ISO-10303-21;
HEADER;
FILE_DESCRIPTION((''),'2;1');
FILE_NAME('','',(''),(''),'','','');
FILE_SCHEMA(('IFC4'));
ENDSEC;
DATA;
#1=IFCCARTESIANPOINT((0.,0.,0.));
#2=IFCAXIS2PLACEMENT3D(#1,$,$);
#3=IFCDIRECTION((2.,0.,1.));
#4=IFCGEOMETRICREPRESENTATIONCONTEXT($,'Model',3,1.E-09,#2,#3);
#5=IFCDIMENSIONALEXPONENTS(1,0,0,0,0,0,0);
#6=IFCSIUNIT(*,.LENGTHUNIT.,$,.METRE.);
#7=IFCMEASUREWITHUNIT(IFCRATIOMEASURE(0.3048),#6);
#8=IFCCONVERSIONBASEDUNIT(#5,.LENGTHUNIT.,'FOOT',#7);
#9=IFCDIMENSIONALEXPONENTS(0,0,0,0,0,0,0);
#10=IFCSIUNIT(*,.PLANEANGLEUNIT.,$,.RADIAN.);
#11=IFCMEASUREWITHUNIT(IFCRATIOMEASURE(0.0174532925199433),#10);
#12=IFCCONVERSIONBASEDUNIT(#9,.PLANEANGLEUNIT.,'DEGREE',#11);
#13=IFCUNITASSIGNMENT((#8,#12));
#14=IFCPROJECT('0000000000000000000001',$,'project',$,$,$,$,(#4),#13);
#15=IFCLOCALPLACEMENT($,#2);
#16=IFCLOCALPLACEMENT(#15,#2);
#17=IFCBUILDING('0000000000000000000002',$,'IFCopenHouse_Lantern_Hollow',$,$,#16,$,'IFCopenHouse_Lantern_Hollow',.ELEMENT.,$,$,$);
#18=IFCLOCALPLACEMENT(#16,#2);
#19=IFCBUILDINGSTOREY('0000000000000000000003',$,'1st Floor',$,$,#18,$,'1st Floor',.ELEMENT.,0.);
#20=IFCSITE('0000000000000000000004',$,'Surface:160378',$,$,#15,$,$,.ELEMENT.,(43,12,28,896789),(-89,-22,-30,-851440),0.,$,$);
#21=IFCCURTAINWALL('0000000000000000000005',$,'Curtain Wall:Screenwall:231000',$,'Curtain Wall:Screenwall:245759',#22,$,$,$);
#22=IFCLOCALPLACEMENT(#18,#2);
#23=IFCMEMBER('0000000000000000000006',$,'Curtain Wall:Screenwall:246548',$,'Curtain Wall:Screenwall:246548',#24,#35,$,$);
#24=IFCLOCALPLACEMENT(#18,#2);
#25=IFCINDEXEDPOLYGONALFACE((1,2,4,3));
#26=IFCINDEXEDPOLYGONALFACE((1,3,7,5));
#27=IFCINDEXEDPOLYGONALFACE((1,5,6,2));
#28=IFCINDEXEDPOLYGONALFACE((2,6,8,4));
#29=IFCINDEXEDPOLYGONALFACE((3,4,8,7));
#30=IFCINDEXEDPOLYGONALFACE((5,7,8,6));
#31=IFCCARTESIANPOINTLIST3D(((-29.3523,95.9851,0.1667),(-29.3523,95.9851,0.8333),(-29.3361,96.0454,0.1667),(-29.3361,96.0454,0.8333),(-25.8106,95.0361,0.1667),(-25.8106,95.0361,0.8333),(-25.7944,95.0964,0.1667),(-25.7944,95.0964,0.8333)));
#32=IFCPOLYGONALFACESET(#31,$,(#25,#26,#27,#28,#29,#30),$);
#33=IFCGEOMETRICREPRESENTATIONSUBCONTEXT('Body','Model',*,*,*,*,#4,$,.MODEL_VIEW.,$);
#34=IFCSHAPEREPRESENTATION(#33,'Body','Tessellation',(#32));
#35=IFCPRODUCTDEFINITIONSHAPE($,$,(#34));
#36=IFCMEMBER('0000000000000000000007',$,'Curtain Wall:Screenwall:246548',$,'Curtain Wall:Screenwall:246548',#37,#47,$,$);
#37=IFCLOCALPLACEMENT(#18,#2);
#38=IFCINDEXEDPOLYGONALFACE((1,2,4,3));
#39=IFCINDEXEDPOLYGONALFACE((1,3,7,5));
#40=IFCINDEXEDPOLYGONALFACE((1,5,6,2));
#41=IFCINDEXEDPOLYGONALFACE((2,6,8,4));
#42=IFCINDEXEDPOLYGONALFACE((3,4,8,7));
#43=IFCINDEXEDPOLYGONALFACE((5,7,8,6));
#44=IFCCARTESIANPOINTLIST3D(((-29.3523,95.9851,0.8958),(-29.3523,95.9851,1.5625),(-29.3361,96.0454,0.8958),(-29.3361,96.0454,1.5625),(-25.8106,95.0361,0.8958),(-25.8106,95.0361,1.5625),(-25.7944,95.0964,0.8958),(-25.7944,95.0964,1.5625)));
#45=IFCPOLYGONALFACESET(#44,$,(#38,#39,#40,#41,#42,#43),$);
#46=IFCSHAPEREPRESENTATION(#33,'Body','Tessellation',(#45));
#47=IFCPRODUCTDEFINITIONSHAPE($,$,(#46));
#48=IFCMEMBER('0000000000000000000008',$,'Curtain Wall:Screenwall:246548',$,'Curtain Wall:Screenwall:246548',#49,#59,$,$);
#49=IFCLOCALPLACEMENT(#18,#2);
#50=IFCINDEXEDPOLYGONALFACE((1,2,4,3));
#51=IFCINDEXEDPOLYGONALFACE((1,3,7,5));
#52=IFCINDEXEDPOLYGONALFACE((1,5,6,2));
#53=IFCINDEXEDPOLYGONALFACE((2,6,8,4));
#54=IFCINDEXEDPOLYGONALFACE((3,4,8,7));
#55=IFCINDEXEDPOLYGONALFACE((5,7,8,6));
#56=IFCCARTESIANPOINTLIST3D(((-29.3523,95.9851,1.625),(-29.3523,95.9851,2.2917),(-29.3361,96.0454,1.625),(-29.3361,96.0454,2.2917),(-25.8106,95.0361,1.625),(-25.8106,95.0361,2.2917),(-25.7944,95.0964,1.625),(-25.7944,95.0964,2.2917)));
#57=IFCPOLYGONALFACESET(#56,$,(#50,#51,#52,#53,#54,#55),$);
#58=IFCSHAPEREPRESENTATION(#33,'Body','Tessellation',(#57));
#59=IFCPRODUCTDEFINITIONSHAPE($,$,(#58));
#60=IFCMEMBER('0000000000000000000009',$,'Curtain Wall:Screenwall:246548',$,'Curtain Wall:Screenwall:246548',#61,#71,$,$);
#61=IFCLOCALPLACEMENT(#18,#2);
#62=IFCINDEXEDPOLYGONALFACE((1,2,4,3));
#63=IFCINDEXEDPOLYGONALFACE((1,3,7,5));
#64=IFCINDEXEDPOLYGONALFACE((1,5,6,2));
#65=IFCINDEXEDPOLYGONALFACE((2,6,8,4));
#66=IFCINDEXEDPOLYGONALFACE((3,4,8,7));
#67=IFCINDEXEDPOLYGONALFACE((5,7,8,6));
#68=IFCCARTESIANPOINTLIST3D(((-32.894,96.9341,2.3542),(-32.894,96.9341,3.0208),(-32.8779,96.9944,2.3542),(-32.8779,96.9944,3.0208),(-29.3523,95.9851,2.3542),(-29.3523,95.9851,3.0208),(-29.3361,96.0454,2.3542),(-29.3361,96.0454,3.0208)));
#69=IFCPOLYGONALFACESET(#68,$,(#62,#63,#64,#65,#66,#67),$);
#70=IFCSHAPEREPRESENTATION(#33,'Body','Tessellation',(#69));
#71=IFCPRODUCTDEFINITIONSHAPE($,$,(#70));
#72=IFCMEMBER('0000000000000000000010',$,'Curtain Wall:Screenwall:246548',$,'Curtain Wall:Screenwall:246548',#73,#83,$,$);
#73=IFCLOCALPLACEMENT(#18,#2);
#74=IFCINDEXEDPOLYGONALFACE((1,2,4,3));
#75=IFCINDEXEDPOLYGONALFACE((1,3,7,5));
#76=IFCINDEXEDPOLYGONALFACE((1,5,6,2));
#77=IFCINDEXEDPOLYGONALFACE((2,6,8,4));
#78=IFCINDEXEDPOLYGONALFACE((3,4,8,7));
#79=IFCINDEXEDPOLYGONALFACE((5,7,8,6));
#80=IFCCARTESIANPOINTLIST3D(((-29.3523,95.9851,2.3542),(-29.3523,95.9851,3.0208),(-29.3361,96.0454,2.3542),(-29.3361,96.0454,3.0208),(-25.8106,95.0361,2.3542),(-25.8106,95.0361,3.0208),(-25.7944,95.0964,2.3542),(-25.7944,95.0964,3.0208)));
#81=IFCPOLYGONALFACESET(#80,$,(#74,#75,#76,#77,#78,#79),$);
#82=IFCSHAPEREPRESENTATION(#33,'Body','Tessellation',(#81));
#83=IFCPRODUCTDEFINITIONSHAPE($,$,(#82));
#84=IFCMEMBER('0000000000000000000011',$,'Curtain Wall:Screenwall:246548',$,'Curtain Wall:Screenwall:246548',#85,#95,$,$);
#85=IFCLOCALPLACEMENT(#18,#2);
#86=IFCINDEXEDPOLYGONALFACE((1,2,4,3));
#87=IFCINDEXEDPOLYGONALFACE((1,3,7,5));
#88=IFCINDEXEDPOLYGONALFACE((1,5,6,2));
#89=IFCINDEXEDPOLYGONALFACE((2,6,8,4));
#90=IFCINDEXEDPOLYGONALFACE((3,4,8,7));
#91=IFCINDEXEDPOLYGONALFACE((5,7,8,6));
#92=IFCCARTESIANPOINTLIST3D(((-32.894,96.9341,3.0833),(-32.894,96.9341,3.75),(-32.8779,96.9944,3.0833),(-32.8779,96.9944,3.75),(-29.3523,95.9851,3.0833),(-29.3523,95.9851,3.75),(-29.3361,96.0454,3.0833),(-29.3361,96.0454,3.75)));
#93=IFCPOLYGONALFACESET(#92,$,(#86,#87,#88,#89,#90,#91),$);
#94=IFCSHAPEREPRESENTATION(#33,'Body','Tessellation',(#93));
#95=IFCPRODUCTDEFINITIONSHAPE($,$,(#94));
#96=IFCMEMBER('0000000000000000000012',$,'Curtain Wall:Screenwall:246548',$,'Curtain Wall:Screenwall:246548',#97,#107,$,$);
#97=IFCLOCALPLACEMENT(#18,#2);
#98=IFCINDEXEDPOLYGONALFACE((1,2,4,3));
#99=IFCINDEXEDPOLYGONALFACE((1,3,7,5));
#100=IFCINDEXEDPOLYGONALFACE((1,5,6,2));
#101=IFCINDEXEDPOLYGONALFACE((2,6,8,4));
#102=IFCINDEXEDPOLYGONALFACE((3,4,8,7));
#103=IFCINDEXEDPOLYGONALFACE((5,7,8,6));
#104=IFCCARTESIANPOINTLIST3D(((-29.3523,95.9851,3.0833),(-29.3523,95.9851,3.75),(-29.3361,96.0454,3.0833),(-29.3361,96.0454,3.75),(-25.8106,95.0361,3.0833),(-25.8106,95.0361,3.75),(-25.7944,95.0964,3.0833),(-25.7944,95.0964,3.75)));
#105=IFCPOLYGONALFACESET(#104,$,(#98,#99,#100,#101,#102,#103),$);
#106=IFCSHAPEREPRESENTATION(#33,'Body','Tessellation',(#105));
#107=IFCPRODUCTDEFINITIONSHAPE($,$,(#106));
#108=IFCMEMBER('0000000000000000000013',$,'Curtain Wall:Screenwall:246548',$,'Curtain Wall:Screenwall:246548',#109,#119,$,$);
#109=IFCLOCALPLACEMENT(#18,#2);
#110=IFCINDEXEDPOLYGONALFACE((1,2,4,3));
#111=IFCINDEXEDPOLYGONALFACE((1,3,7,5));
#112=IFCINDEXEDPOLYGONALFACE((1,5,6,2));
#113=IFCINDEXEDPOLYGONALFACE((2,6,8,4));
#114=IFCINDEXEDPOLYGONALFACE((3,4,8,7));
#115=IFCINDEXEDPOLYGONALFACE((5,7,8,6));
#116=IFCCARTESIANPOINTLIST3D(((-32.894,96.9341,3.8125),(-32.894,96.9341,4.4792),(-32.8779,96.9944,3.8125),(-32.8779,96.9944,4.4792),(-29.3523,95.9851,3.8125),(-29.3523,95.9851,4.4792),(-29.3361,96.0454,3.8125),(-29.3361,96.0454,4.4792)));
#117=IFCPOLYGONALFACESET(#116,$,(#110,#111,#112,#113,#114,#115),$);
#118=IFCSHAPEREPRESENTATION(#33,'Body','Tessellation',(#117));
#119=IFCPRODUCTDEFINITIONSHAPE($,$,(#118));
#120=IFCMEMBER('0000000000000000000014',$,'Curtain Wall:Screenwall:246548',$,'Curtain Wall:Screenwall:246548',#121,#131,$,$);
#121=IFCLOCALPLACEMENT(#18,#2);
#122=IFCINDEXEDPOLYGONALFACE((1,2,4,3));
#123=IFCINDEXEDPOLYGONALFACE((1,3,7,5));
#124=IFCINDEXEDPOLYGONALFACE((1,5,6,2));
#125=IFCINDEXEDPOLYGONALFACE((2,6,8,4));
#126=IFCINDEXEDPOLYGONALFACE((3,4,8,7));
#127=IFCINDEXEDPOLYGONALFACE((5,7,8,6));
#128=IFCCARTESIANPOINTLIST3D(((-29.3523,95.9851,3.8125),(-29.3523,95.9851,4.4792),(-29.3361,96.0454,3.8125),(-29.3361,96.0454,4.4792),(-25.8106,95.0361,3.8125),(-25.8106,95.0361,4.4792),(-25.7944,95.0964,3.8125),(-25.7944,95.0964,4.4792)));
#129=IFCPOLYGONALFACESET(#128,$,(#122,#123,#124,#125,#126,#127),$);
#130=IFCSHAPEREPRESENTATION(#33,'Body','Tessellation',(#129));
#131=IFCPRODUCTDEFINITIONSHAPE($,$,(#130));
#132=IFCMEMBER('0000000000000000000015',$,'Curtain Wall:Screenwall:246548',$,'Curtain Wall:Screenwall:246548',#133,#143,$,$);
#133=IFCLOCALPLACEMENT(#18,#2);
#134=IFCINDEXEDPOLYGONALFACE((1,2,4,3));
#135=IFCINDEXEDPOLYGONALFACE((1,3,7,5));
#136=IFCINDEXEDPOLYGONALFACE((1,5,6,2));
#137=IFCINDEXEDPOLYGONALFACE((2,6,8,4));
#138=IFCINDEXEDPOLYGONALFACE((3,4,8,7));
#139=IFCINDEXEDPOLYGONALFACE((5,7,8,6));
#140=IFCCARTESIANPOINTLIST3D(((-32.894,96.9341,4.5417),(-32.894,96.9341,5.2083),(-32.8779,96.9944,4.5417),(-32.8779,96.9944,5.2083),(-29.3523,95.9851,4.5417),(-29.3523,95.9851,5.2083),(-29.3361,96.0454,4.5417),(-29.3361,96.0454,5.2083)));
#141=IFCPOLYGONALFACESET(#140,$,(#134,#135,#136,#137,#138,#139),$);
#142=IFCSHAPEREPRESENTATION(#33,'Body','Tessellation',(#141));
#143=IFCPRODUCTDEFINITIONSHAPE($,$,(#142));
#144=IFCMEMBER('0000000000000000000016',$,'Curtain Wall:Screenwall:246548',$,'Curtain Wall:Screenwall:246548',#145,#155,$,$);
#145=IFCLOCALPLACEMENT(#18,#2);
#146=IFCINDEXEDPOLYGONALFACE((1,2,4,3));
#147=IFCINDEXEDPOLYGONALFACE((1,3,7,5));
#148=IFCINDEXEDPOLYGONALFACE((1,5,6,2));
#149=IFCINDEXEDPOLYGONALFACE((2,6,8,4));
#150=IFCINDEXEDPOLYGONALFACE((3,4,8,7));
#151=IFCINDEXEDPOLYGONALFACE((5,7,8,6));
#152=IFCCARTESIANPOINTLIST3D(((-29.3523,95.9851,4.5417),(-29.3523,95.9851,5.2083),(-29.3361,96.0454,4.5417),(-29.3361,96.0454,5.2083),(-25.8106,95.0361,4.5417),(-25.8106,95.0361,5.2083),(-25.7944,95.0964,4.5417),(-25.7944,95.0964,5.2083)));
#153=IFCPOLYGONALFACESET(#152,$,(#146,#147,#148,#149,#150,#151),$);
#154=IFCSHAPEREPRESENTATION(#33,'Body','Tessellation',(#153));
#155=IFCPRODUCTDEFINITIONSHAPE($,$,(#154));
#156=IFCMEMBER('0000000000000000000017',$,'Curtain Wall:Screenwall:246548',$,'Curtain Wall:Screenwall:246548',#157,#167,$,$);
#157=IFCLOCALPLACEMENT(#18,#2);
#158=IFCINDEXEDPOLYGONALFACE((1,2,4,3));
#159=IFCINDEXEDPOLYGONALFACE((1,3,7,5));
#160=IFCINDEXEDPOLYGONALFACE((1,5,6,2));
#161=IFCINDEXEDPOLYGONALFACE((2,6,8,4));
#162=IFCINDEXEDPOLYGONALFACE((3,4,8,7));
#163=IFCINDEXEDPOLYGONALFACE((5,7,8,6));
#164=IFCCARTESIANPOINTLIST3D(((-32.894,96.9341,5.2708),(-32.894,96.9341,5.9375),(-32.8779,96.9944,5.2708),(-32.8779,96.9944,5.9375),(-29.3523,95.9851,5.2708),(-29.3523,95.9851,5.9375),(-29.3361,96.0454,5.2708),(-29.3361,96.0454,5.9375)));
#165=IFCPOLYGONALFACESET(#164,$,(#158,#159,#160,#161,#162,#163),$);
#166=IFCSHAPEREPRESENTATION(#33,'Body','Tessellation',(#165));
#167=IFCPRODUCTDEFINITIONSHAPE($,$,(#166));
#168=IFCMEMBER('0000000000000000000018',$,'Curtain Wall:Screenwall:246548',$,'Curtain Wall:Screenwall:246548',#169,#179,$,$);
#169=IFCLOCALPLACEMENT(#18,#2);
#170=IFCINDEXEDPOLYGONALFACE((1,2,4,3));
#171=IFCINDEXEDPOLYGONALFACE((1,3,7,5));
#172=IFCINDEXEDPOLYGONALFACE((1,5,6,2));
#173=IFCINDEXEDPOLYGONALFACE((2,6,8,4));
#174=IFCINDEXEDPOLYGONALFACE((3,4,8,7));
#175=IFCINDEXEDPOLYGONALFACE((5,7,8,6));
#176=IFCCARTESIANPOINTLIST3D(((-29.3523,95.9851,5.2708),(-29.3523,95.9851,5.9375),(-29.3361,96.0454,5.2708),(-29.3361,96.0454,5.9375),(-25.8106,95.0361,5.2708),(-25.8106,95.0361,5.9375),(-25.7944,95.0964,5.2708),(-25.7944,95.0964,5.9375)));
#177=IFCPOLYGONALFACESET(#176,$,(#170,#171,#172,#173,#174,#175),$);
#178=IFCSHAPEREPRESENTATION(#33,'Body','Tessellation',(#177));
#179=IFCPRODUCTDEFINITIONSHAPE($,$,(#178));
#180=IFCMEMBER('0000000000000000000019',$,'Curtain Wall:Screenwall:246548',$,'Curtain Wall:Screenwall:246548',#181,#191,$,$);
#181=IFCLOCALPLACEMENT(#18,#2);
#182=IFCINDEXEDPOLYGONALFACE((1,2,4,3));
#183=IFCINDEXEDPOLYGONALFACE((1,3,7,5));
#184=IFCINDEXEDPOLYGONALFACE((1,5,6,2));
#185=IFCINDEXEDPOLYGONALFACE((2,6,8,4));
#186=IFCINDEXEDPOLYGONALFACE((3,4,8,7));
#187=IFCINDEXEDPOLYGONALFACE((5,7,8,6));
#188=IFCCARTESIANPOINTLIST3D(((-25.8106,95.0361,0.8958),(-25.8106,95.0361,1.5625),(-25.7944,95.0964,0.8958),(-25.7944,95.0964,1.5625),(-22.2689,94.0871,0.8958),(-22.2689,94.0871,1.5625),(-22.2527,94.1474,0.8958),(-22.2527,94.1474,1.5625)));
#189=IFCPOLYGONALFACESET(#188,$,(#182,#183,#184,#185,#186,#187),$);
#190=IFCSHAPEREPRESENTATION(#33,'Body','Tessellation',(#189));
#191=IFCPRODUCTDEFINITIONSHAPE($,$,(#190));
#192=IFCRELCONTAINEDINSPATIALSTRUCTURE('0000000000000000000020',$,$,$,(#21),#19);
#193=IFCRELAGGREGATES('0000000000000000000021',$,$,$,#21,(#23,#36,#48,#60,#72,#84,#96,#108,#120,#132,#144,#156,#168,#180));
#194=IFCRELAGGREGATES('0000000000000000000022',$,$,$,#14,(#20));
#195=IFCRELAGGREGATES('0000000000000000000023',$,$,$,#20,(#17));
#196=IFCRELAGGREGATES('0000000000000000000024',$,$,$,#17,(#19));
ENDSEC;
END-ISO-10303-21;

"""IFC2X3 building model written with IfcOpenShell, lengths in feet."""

from ifc_helpers import new_model, entity, si_unit, converted_unit, direction, frame, frame_2d, origin, origin_2d_with_axis, place, context, subcontext, project, spatial, rectangle, extrude, element, aggregate, save


model = new_model("IFC2X3")

# Units and contexts
model_context = context("Model", 3, precision=1e-09, world=origin(), true_north=direction((2.0, 0.0, 1.0)))
body_context = subcontext(model_context, "Body", "Model", "MODEL_VIEW")
ifc_project = project(units=[converted_unit("LENGTHUNIT", "FOOT", entity("IfcRatioMeasure", 0.3048), si_unit("LENGTHUNIT", "METRE"), dimensions=[1, 0, 0, 0, 0, 0, 0]), converted_unit("PLANEANGLEUNIT", "DEGREE", entity("IfcRatioMeasure", 0.0174532925199433), si_unit("PLANEANGLEUNIT", "RADIAN"), dimensions=[0, 0, 0, 0, 0, 0, 0])], contexts=[model_context])

# Site, building, storey
site_placement = place(None, origin())
site = spatial("IfcSite", under=ifc_project, at=site_placement, Name="Surface:160378", CompositionType="ELEMENT", RefLatitude=(43, 12, 28, 896789), RefLongitude=(-89, -22, -30, -851440), RefElevation=0.0)
building_placement = place(site_placement, origin())
building = spatial("IfcBuilding", under=site, at=building_placement, Name="IFCopenHouse_Lantern_Hollow", LongName="IFCopenHouse_Lantern_Hollow", CompositionType="ELEMENT")
storey_placement = place(building_placement, origin())
storey = spatial("IfcBuildingStorey", under=building, at=storey_placement, Name="1st Floor", LongName="1st Floor", CompositionType="ELEMENT", Elevation=0.0)

# Curtain wall, members
curtain_wall_placement = place(storey_placement, origin())
curtain_wall = element("IfcCurtainWall", 1, at=curtain_wall_placement, inside=storey, Name="Curtain Wall:Screenwall:231000", ObjectType="Curtain Wall:Screenwall:245759")
member_1_placement = place(curtain_wall_placement, frame((-29.3523, 95.0361, 0.1667)))
member_1 = element("IfcMember", 2, at=member_1_placement, Name="Curtain Wall:Screenwall:246548", ObjectType="Curtain Wall:Screenwall:246548", context=body_context, shape_type="SweptSolid", body=[
    extrude(rectangle(XDim=3.6667, YDim=0.0625, at=frame_2d((0.0, 0.0), x_axis=(1.0, 0.0))), frame((1.779, 0.5047, 0.0), z_axis=(0.0, 0.0, 1.0), x_axis=(-0.965926, 0.258819, 0.0)), (0.0, 0.0, 1.0), 0.6667),
])
member_2_placement = place(curtain_wall_placement, frame((-29.3523, 95.0361, 0.8958)))
member_2 = element("IfcMember", 3, at=member_2_placement, Name="Curtain Wall:Screenwall:246548", ObjectType="Curtain Wall:Screenwall:246548", context=body_context, shape_type="SweptSolid", body=[
    extrude(rectangle(XDim=3.6667, YDim=0.0625, at=frame_2d((0.0, 0.0), x_axis=(1.0, 0.0))), frame((1.779, 0.5047, 0.0), z_axis=(0.0, 0.0, 1.0), x_axis=(-0.965926, 0.258819, 0.0)), (0.0, 0.0, 1.0), 0.6667),
])
member_3_placement = place(curtain_wall_placement, frame((-29.3523, 95.0361, 1.625)))
member_3 = element("IfcMember", 4, at=member_3_placement, Name="Curtain Wall:Screenwall:246548", ObjectType="Curtain Wall:Screenwall:246548", context=body_context, shape_type="SweptSolid", body=[
    extrude(rectangle(XDim=3.6667, YDim=0.0625, at=frame_2d((0.0, 0.0), x_axis=(1.0, 0.0))), frame((1.779, 0.5047, 0.0), z_axis=(0.0, 0.0, 1.0), x_axis=(-0.965926, 0.258819, 0.0)), (0.0, 0.0, 1.0), 0.6667),
])
member_4_placement = place(curtain_wall_placement, frame((-32.894, 95.9851, 2.3542)))
member_4 = element("IfcMember", 5, at=member_4_placement, Name="Curtain Wall:Screenwall:246548", ObjectType="Curtain Wall:Screenwall:246548", context=body_context, shape_type="SweptSolid", body=[
    extrude(rectangle(XDim=3.6667, YDim=0.0625, at=frame_2d((0.0, 0.0), x_axis=(1.0, 0.0))), frame((1.779, 0.5047, 0.0), z_axis=(0.0, 0.0, 1.0), x_axis=(-0.965926, 0.258819, 0.0)), (0.0, 0.0, 1.0), 0.6667),
])
member_5_placement = place(curtain_wall_placement, frame((-29.3523, 95.0361, 2.3542)))
member_5 = element("IfcMember", 6, at=member_5_placement, Name="Curtain Wall:Screenwall:246548", ObjectType="Curtain Wall:Screenwall:246548", context=body_context, shape_type="SweptSolid", body=[
    extrude(rectangle(XDim=3.6667, YDim=0.0625, at=frame_2d((0.0, 0.0), x_axis=(1.0, 0.0))), frame((1.779, 0.5047, 0.0), z_axis=(0.0, 0.0, 1.0), x_axis=(-0.965926, 0.258819, 0.0)), (0.0, 0.0, 1.0), 0.6667),
])
member_6_placement = place(curtain_wall_placement, frame((-32.894, 95.9851, 3.0833)))
member_6 = element("IfcMember", 7, at=member_6_placement, Name="Curtain Wall:Screenwall:246548", ObjectType="Curtain Wall:Screenwall:246548", context=body_context, shape_type="SweptSolid", body=[
    extrude(rectangle(XDim=3.6667, YDim=0.0625, at=frame_2d((0.0, 0.0), x_axis=(1.0, 0.0))), frame((1.779, 0.5047, 0.0), z_axis=(0.0, 0.0, 1.0), x_axis=(-0.965926, 0.258819, 0.0)), (0.0, 0.0, 1.0), 0.6667),
])
member_7_placement = place(curtain_wall_placement, frame((-29.3523, 95.0361, 3.0833)))
member_7 = element("IfcMember", 8, at=member_7_placement, Name="Curtain Wall:Screenwall:246548", ObjectType="Curtain Wall:Screenwall:246548", context=body_context, shape_type="SweptSolid", body=[
    extrude(rectangle(XDim=3.6667, YDim=0.0625, at=frame_2d((0.0, 0.0), x_axis=(1.0, 0.0))), frame((1.779, 0.5047, 0.0), z_axis=(0.0, 0.0, 1.0), x_axis=(-0.965926, 0.258819, 0.0)), (0.0, 0.0, 1.0), 0.6667),
])
member_8_placement = place(curtain_wall_placement, frame((-32.894, 95.9851, 3.8125)))
member_8 = element("IfcMember", 9, at=member_8_placement, Name="Curtain Wall:Screenwall:246548", ObjectType="Curtain Wall:Screenwall:246548", context=body_context, shape_type="SweptSolid", body=[
    extrude(rectangle(XDim=3.6667, YDim=0.0625, at=frame_2d((0.0, 0.0), x_axis=(1.0, 0.0))), frame((1.779, 0.5047, 0.0), z_axis=(0.0, 0.0, 1.0), x_axis=(-0.965926, 0.258819, 0.0)), (0.0, 0.0, 1.0), 0.6667),
])
member_9_placement = place(curtain_wall_placement, frame((-29.3523, 95.0361, 3.8125)))
member_9 = element("IfcMember", 10, at=member_9_placement, Name="Curtain Wall:Screenwall:246548", ObjectType="Curtain Wall:Screenwall:246548", context=body_context, shape_type="SweptSolid", body=[
    extrude(rectangle(XDim=3.6667, YDim=0.0625, at=frame_2d((0.0, 0.0), x_axis=(1.0, 0.0))), frame((1.779, 0.5047, 0.0), z_axis=(0.0, 0.0, 1.0), x_axis=(-0.965926, 0.258819, 0.0)), (0.0, 0.0, 1.0), 0.6667),
])
member_10_placement = place(curtain_wall_placement, frame((-32.894, 95.9851, 4.5417)))
member_10 = element("IfcMember", 11, at=member_10_placement, Name="Curtain Wall:Screenwall:246548", ObjectType="Curtain Wall:Screenwall:246548", context=body_context, shape_type="SweptSolid", body=[
    extrude(rectangle(XDim=3.6667, YDim=0.0625, at=frame_2d((0.0, 0.0), x_axis=(1.0, 0.0))), frame((1.779, 0.5047, 0.0), z_axis=(0.0, 0.0, 1.0), x_axis=(-0.965926, 0.258819, 0.0)), (0.0, 0.0, 1.0), 0.6667),
])
member_11_placement = place(curtain_wall_placement, frame((-29.3523, 95.0361, 4.5417)))
member_11 = element("IfcMember", 12, at=member_11_placement, Name="Curtain Wall:Screenwall:246548", ObjectType="Curtain Wall:Screenwall:246548", context=body_context, shape_type="SweptSolid", body=[
    extrude(rectangle(XDim=3.6667, YDim=0.0625, at=frame_2d((0.0, 0.0), x_axis=(1.0, 0.0))), frame((1.779, 0.5047, 0.0), z_axis=(0.0, 0.0, 1.0), x_axis=(-0.965926, 0.258819, 0.0)), (0.0, 0.0, 1.0), 0.6667),
])
member_12_placement = place(curtain_wall_placement, frame((-32.894, 95.9851, 5.2708)))
member_12 = element("IfcMember", 13, at=member_12_placement, Name="Curtain Wall:Screenwall:246548", ObjectType="Curtain Wall:Screenwall:246548", context=body_context, shape_type="SweptSolid", body=[
    extrude(rectangle(XDim=3.6667, YDim=0.0625, at=frame_2d((0.0, 0.0), x_axis=(1.0, 0.0))), frame((1.779, 0.5047, 0.0), z_axis=(0.0, 0.0, 1.0), x_axis=(-0.965926, 0.258819, 0.0)), (0.0, 0.0, 1.0), 0.6667),
])
member_13_placement = place(curtain_wall_placement, frame((-29.3523, 95.0361, 5.2708)))
member_13 = element("IfcMember", 14, at=member_13_placement, Name="Curtain Wall:Screenwall:246548", ObjectType="Curtain Wall:Screenwall:246548", context=body_context, shape_type="SweptSolid", body=[
    extrude(rectangle(XDim=3.6667, YDim=0.0625, at=frame_2d((0.0, 0.0), x_axis=(1.0, 0.0))), frame((1.779, 0.5047, 0.0), z_axis=(0.0, 0.0, 1.0), x_axis=(-0.965926, 0.258819, 0.0)), (0.0, 0.0, 1.0), 0.6667),
])
member_14_placement = place(curtain_wall_placement, frame((-25.8106, 94.0871, 0.8958)))
member_14 = element("IfcMember", 15, at=member_14_placement, Name="Curtain Wall:Screenwall:246548", ObjectType="Curtain Wall:Screenwall:246548", context=body_context, shape_type="SweptSolid", body=[
    extrude(rectangle(XDim=3.6667, YDim=0.0625, at=origin_2d_with_axis()), frame((1.779, 0.5047, 0.0), z_axis=(0.0, 0.0, 1.0), x_axis=(-0.965926, 0.258819, 0.0)), (0.0, 0.0, 1.0), 0.6667),
])
aggregate(curtain_wall, [member_1, member_2, member_3, member_4, member_5, member_6, member_7, member_8, member_9, member_10, member_11, member_12, member_13, member_14])

save(model, "model.ifc")
